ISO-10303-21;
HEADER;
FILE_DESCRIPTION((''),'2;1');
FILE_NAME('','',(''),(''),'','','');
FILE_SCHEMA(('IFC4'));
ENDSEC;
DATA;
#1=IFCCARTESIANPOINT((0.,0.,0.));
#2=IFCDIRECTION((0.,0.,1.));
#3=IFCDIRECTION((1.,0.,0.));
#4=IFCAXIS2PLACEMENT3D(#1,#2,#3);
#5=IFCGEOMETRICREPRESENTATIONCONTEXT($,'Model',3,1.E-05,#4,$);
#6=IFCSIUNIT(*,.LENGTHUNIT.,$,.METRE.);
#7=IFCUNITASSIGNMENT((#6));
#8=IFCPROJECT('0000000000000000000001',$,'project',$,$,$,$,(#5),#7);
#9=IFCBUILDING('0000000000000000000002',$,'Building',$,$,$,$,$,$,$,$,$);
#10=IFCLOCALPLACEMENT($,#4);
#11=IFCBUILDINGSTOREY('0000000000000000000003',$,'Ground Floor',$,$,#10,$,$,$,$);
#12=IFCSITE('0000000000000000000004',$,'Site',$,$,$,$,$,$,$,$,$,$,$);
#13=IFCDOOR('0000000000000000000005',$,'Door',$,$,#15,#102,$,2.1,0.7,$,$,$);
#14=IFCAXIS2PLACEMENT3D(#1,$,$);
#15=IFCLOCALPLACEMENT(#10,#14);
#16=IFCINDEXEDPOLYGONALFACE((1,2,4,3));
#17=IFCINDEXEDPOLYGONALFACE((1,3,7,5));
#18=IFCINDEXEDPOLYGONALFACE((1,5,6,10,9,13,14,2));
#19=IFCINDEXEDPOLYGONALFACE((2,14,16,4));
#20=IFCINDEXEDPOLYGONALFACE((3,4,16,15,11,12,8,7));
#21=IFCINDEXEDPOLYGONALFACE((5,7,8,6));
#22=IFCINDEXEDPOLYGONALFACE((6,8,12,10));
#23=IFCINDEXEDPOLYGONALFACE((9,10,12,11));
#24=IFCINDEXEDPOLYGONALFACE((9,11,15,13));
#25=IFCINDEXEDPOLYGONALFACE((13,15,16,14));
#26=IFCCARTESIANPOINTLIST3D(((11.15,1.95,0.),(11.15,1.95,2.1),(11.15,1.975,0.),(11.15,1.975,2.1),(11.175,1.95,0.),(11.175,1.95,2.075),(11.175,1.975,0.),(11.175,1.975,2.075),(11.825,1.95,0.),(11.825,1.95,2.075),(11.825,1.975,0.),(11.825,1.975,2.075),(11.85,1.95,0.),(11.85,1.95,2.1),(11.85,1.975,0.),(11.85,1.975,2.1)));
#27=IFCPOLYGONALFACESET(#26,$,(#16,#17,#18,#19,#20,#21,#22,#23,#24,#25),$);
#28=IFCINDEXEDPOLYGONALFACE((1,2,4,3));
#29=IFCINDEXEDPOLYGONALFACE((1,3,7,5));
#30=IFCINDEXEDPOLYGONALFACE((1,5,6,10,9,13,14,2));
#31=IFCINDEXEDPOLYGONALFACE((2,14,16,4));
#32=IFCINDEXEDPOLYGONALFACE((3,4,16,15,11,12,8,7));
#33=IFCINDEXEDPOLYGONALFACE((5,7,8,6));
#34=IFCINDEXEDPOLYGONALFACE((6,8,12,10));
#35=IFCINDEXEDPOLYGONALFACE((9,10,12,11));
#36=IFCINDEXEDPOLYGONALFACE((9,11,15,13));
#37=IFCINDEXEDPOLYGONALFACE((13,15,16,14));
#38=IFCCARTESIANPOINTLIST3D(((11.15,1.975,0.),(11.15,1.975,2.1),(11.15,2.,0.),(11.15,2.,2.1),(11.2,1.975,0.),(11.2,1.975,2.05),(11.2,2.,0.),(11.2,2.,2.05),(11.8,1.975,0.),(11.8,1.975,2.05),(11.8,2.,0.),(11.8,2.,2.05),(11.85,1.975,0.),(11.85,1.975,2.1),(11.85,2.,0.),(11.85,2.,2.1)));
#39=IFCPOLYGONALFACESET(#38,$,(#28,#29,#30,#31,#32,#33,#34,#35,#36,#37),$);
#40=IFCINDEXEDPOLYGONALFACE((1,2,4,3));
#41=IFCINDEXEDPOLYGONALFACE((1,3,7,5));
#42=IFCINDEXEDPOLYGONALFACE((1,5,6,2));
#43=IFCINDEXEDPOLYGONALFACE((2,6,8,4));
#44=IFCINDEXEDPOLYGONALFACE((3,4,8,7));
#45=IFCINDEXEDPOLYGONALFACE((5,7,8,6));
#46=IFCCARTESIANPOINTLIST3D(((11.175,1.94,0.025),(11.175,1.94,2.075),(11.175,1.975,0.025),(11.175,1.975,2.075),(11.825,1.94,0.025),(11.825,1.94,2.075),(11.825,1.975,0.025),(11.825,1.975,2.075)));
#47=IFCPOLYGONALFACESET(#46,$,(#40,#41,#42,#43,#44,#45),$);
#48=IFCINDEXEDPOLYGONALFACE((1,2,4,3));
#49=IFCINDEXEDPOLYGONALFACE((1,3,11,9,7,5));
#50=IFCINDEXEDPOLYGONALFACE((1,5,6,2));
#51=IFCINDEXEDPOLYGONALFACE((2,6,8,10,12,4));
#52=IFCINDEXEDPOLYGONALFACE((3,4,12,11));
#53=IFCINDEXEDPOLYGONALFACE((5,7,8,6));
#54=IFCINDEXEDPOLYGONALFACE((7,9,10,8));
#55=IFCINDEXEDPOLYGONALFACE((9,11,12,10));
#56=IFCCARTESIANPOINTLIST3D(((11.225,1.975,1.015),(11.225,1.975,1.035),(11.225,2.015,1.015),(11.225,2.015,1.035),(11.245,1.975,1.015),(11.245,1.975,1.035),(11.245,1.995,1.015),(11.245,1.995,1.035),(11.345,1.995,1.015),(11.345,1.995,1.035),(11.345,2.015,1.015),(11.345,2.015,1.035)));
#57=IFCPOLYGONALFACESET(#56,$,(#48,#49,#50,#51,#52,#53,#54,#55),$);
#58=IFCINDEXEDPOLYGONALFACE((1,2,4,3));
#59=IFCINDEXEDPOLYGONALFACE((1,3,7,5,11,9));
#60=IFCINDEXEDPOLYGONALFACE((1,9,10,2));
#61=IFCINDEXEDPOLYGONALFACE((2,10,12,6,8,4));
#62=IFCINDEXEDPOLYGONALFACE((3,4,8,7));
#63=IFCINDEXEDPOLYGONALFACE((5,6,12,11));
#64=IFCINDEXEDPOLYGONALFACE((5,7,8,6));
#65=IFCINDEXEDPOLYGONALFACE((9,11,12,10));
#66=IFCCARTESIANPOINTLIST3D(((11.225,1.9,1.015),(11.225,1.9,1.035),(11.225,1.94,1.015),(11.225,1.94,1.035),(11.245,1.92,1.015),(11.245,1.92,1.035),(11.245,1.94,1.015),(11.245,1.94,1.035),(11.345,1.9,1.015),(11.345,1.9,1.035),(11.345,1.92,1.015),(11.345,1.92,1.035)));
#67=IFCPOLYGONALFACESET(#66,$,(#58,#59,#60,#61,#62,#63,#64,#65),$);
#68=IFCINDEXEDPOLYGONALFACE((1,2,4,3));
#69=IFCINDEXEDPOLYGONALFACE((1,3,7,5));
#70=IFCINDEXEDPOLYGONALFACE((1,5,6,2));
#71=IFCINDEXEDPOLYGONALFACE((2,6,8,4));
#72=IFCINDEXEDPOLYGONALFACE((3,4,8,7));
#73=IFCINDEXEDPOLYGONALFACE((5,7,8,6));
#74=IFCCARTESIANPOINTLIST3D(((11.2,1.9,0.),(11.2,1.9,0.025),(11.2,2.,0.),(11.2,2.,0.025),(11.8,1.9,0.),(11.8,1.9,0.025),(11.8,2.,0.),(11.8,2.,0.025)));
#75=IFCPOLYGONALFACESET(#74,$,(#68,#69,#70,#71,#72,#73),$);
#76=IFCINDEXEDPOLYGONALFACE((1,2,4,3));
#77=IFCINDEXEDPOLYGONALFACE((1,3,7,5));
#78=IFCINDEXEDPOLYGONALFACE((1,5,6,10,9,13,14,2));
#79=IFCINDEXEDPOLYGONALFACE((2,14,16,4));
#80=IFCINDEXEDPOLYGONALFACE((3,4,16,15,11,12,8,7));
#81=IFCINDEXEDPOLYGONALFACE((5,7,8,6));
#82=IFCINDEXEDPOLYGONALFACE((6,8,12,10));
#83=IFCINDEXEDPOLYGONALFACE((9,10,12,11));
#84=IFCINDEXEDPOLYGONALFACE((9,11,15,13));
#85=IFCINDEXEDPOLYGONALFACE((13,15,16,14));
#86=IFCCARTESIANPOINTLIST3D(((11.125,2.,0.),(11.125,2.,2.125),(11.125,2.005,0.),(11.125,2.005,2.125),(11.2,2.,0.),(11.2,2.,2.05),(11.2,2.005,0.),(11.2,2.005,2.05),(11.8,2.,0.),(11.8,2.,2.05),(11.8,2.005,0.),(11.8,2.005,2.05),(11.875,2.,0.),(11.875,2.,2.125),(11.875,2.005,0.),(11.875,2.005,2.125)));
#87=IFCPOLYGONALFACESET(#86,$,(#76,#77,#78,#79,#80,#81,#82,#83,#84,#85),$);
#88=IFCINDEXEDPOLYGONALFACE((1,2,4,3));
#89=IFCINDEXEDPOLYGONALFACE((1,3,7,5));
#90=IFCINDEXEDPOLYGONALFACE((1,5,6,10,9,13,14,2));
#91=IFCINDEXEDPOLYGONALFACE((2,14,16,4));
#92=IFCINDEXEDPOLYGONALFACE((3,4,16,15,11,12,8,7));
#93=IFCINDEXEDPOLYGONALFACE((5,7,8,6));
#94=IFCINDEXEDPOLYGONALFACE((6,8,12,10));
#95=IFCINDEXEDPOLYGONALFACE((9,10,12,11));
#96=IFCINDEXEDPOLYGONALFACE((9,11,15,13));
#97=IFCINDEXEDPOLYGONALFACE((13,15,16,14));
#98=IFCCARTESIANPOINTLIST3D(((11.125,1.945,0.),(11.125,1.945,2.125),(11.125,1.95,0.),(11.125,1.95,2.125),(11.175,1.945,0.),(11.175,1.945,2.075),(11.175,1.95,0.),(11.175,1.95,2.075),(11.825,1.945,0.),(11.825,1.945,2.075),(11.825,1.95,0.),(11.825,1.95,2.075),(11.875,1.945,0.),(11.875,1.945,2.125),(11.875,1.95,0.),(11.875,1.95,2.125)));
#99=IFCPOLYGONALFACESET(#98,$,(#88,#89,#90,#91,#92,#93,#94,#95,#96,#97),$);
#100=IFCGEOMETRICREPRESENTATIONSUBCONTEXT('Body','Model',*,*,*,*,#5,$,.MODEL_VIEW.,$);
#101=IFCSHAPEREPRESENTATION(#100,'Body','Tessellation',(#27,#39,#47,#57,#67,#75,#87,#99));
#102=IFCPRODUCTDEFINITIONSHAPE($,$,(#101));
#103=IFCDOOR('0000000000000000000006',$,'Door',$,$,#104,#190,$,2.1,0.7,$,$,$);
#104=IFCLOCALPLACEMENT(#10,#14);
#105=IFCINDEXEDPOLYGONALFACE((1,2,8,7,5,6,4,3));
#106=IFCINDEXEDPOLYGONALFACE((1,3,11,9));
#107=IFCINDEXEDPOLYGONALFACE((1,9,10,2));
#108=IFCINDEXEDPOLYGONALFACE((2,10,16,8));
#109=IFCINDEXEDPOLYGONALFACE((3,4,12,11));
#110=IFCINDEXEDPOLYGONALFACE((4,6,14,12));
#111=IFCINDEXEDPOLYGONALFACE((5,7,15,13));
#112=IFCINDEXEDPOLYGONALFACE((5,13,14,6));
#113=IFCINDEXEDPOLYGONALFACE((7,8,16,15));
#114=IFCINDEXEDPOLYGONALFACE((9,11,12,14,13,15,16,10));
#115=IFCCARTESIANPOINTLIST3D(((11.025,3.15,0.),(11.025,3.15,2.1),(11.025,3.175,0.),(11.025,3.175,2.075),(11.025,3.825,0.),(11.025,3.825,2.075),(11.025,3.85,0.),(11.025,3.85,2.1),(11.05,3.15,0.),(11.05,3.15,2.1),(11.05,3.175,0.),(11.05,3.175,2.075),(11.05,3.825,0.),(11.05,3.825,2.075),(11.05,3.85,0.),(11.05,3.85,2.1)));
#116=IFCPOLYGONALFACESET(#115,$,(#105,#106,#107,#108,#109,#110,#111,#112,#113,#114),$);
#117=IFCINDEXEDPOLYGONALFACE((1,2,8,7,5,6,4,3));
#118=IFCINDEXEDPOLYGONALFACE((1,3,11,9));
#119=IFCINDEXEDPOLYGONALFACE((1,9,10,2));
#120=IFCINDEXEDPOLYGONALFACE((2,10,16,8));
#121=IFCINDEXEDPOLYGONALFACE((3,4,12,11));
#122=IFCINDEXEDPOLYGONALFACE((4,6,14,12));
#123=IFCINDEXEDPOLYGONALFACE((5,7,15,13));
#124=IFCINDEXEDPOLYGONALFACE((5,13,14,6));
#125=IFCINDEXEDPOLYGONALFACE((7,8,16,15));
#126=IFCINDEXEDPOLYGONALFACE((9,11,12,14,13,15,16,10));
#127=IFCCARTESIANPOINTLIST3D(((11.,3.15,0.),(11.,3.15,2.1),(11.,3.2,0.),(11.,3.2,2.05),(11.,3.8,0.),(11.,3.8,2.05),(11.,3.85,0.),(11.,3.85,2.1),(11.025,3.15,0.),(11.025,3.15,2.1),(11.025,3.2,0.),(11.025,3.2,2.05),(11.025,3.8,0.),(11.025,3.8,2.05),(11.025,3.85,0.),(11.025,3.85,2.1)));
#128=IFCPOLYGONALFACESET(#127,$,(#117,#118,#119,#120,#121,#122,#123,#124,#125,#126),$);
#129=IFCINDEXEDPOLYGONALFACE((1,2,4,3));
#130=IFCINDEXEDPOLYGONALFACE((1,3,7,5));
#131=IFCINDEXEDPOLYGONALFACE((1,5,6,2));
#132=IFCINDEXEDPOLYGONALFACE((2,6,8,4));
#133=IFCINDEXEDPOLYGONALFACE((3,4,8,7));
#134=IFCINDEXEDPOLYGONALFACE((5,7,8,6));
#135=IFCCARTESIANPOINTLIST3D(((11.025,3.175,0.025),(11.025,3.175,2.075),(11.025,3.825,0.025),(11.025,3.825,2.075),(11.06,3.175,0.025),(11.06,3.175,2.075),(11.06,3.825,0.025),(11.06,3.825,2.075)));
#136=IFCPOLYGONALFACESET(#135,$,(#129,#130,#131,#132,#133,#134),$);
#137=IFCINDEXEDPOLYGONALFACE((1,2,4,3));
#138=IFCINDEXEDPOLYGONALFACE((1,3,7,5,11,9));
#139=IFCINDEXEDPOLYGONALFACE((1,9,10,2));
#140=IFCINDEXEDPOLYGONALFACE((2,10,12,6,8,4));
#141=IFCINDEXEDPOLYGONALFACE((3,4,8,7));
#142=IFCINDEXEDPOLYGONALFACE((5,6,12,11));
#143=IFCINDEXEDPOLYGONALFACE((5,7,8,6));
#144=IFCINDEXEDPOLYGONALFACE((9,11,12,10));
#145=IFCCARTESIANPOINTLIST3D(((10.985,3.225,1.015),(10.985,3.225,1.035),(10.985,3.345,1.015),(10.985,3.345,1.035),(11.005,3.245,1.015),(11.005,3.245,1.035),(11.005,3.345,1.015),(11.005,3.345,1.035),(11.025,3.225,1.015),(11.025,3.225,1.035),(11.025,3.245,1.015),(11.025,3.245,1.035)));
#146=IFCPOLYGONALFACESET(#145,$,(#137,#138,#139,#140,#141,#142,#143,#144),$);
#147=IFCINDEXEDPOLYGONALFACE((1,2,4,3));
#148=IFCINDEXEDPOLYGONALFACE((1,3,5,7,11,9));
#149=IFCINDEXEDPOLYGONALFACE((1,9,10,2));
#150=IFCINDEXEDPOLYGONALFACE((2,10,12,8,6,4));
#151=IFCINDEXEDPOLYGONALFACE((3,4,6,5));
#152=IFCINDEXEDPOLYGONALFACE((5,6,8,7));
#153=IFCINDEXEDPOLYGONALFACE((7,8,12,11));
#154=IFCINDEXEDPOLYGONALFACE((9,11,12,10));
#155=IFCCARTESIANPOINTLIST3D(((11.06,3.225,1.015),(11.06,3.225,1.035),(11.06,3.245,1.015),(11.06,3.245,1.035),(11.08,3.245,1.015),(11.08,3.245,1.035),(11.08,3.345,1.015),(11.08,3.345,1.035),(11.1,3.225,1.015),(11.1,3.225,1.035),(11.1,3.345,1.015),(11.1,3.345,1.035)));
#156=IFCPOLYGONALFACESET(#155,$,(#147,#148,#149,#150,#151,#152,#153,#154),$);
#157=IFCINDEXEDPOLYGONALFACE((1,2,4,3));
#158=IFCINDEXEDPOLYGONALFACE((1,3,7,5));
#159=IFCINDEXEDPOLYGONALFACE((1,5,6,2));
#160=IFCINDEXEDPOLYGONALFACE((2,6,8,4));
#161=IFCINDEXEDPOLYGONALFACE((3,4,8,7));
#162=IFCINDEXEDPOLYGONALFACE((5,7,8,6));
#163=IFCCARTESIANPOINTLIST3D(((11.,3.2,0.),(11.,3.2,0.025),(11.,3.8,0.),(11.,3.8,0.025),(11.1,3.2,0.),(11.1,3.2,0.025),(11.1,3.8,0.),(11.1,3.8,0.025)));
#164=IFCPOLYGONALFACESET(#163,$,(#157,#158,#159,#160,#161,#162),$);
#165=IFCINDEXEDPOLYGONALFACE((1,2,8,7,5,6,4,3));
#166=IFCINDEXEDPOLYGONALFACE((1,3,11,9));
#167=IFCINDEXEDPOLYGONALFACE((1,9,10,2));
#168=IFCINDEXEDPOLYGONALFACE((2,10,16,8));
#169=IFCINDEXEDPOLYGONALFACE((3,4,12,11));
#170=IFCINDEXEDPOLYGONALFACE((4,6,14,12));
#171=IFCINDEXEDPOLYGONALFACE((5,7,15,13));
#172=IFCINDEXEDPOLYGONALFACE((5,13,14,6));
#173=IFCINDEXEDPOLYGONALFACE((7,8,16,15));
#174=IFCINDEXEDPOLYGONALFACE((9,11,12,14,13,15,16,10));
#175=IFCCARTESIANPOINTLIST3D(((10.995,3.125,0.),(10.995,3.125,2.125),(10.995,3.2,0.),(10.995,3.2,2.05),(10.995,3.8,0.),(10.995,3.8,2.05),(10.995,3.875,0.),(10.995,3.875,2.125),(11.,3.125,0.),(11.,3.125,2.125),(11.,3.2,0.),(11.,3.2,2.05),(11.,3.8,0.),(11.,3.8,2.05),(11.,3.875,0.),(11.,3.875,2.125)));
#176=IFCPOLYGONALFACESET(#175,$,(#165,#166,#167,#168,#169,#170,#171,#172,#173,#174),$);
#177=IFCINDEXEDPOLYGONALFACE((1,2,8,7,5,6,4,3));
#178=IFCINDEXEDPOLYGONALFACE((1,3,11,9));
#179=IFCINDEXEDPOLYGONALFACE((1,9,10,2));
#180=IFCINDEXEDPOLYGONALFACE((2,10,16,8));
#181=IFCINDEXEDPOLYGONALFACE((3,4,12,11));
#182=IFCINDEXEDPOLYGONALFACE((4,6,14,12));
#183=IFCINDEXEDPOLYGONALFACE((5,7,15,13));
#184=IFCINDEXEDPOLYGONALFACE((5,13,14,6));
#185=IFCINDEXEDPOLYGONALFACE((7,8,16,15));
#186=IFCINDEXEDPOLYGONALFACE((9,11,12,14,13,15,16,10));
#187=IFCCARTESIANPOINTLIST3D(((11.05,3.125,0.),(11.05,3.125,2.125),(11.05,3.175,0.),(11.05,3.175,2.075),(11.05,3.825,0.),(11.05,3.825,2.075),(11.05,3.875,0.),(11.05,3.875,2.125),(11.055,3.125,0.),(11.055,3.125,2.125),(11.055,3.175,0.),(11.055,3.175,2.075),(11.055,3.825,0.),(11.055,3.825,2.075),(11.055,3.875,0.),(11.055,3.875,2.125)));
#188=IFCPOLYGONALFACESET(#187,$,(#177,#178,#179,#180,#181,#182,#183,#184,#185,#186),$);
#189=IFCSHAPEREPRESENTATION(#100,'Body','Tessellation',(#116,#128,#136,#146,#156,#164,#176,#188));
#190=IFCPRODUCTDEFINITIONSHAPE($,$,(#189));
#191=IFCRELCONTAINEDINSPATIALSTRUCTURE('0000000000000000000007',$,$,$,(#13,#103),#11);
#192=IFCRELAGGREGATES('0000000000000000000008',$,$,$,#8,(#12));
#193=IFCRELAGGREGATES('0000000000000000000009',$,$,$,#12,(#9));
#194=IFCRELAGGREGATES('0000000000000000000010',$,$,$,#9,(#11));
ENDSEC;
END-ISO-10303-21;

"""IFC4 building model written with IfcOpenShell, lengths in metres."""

from ifc_helpers import new_model, si_unit, frame, origin_with_axes, place, context, subcontext, project, spatial, line, indexed_curve, outline, extrude, element, save


model = new_model("IFC4")

# Units and contexts
model_context = context("Model", 3, precision=1e-05, world=origin_with_axes())
body_context = subcontext(model_context, "Body", "Model", "MODEL_VIEW")
ifc_project = project(units=[si_unit("LENGTHUNIT", "METRE")], contexts=[model_context])

# Site, building, storey
site = spatial("IfcSite", under=ifc_project, Name="Site")
building = spatial("IfcBuilding", under=site, Name="Building")
storey_placement = place(None, origin_with_axes())
storey = spatial("IfcBuildingStorey", under=building, at=storey_placement, Name="Ground Floor")

# Doors
door_1_placement = place(storey_placement, frame((11.85, 2.0, 0.0), z_axis=(0.0, 0.0, 1.0), x_axis=(-1.0, 0.0, 0.0)))
element("IfcDoor", 1, at=door_1_placement, inside=storey, Name="Door", OverallHeight=2.1, OverallWidth=0.7, context=body_context, shape_type="SweptSolid", body=[
    extrude(outline(indexed_curve([(0.0, 0.0), (0.0, 2.1), (0.7, 2.1), (0.7, 0.0), (0.675, 0.0), (0.675, 2.075), (0.025, 2.075), (0.025, 0.0)], segments=[line(1, 2, 3, 4, 5, 6, 7, 8, 1)])), frame((0.0, 0.025, 0.0), z_axis=(0.0, -1.0, 0.0), x_axis=(1.0, 0.0, 0.0)), (0.0, 0.0, -1.0), 0.025),
    extrude(outline(indexed_curve([(0.0, 0.0), (0.0, 2.1), (0.7, 2.1), (0.7, 0.0), (0.65, 0.0), (0.65, 2.05), (0.05, 2.05), (0.05, 0.0)], segments=[line(1, 2, 3, 4, 5, 6, 7, 8, 1)])), frame((0.0, 0.0, 0.0), z_axis=(0.0, -1.0, 0.0), x_axis=(1.0, 0.0, 0.0)), (0.0, 0.0, -1.0), 0.025),
    extrude(outline(indexed_curve([(0.0, 0.0), (0.65, 0.0), (0.65, 0.035), (0.0, 0.035)], segments=[line(1, 2, 3, 4, 1)])), frame((0.025, 0.025, 0.025), z_axis=(0.0, 0.0, 1.0), x_axis=(1.0, 0.0, 0.0)), (0.0, 0.0, 1.0), 2.05),
    extrude(outline(indexed_curve([(0.0, 0.0), (0.0, -0.04), (-0.12, -0.04), (-0.12, -0.02), (-0.02, -0.02), (-0.02, 0.0)], segments=[line(1, 2, 3, 4, 5, 6, 1)])), frame((0.625, 0.025, 1.015), z_axis=(0.0, 0.0, 1.0), x_axis=(1.0, 0.0, 0.0)), (0.0, 0.0, 1.0), 0.02),
    extrude(outline(indexed_curve([(0.0, 0.0), (0.0, 0.04), (-0.12, 0.04), (-0.12, 0.02), (-0.02, 0.02), (-0.02, 0.0)], segments=[line(1, 2, 3, 4, 5, 6, 1)])), frame((0.625, 0.06, 1.015), z_axis=(0.0, 0.0, 1.0), x_axis=(1.0, 0.0, 0.0)), (0.0, 0.0, 1.0), 0.02),
    extrude(outline(indexed_curve([(0.0, 0.0), (0.6, 0.0), (0.6, 0.1), (0.0, 0.1)], segments=[line(1, 2, 3, 4, 1)])), frame((0.05, 0.0, 0.0), z_axis=(0.0, 0.0, 1.0), x_axis=(1.0, 0.0, 0.0)), (0.0, 0.0, 1.0), 0.025),
    extrude(outline(indexed_curve([(0.0, 0.0), (0.0, 2.125), (0.75, 2.125), (0.75, 0.0), (0.675, 0.0), (0.675, 2.05), (0.075, 2.05), (0.075, 0.0)], segments=[line(1, 2, 3, 4, 5, 6, 7, 8, 1)])), frame((-0.025, -0.005, 0.0), z_axis=(0.0, -1.0, 0.0), x_axis=(1.0, 0.0, 0.0)), (0.0, 0.0, -1.0), 0.005),
    extrude(outline(indexed_curve([(0.0, 0.0), (0.0, 2.125), (0.75, 2.125), (0.75, 0.0), (0.7, 0.0), (0.7, 2.075), (0.05, 2.075), (0.05, 0.0)], segments=[line(1, 2, 3, 4, 5, 6, 7, 8, 1)])), frame((-0.025, 0.05, 0.0), z_axis=(0.0, -1.0, 0.0), x_axis=(1.0, 0.0, 0.0)), (0.0, 0.0, -1.0), 0.005),
])
door_2_placement = place(storey_placement, frame((11.0, 3.85, 0.0), z_axis=(0.0, 0.0, 1.0), x_axis=(0.0, -1.0, 0.0)))
element("IfcDoor", 2, at=door_2_placement, inside=storey, Name="Door", OverallHeight=2.1, OverallWidth=0.7, context=body_context, shape_type="SweptSolid", body=[
    extrude(outline(indexed_curve([(0.0, 0.0), (0.0, 2.1), (0.7, 2.1), (0.7, 0.0), (0.675, 0.0), (0.675, 2.075), (0.025, 2.075), (0.025, 0.0)], segments=[line(1, 2, 3, 4, 5, 6, 7, 8, 1)])), frame((0.0, 0.025, 0.0), z_axis=(0.0, -1.0, 0.0), x_axis=(1.0, 0.0, 0.0)), (0.0, 0.0, -1.0), 0.025),
    extrude(outline(indexed_curve([(0.0, 0.0), (0.0, 2.1), (0.7, 2.1), (0.7, 0.0), (0.65, 0.0), (0.65, 2.05), (0.05, 2.05), (0.05, 0.0)], segments=[line(1, 2, 3, 4, 5, 6, 7, 8, 1)])), frame((0.0, 0.0, 0.0), z_axis=(0.0, -1.0, 0.0), x_axis=(1.0, 0.0, 0.0)), (0.0, 0.0, -1.0), 0.025),
    extrude(outline(indexed_curve([(0.0, 0.0), (0.65, 0.0), (0.65, 0.035), (0.0, 0.035)], segments=[line(1, 2, 3, 4, 1)])), frame((0.025, 0.025, 0.025), z_axis=(0.0, 0.0, 1.0), x_axis=(1.0, 0.0, 0.0)), (0.0, 0.0, 1.0), 2.05),
    extrude(outline(indexed_curve([(0.0, 0.0), (0.0, -0.04), (-0.12, -0.04), (-0.12, -0.02), (-0.02, -0.02), (-0.02, 0.0)], segments=[line(1, 2, 3, 4, 5, 6, 1)])), frame((0.625, 0.025, 1.015), z_axis=(0.0, 0.0, 1.0), x_axis=(1.0, 0.0, 0.0)), (0.0, 0.0, 1.0), 0.02),
    extrude(outline(indexed_curve([(0.0, 0.0), (0.0, 0.04), (-0.12, 0.04), (-0.12, 0.02), (-0.02, 0.02), (-0.02, 0.0)], segments=[line(1, 2, 3, 4, 5, 6, 1)])), frame((0.625, 0.06, 1.015), z_axis=(0.0, 0.0, 1.0), x_axis=(1.0, 0.0, 0.0)), (0.0, 0.0, 1.0), 0.02),
    extrude(outline(indexed_curve([(0.0, 0.0), (0.6, 0.0), (0.6, 0.1), (0.0, 0.1)], segments=[line(1, 2, 3, 4, 1)])), frame((0.05, 0.0, 0.0), z_axis=(0.0, 0.0, 1.0), x_axis=(1.0, 0.0, 0.0)), (0.0, 0.0, 1.0), 0.025),
    extrude(outline(indexed_curve([(0.0, 0.0), (0.0, 2.125), (0.75, 2.125), (0.75, 0.0), (0.675, 0.0), (0.675, 2.05), (0.075, 2.05), (0.075, 0.0)], segments=[line(1, 2, 3, 4, 5, 6, 7, 8, 1)])), frame((-0.025, -0.005, 0.0), z_axis=(0.0, -1.0, 0.0), x_axis=(1.0, 0.0, 0.0)), (0.0, 0.0, -1.0), 0.005),
    extrude(outline(indexed_curve([(0.0, 0.0), (0.0, 2.125), (0.75, 2.125), (0.75, 0.0), (0.7, 0.0), (0.7, 2.075), (0.05, 2.075), (0.05, 0.0)], segments=[line(1, 2, 3, 4, 5, 6, 7, 8, 1)])), frame((-0.025, 0.05, 0.0), z_axis=(0.0, -1.0, 0.0), x_axis=(1.0, 0.0, 0.0)), (0.0, 0.0, -1.0), 0.005),
])

save(model, "model.ifc")
